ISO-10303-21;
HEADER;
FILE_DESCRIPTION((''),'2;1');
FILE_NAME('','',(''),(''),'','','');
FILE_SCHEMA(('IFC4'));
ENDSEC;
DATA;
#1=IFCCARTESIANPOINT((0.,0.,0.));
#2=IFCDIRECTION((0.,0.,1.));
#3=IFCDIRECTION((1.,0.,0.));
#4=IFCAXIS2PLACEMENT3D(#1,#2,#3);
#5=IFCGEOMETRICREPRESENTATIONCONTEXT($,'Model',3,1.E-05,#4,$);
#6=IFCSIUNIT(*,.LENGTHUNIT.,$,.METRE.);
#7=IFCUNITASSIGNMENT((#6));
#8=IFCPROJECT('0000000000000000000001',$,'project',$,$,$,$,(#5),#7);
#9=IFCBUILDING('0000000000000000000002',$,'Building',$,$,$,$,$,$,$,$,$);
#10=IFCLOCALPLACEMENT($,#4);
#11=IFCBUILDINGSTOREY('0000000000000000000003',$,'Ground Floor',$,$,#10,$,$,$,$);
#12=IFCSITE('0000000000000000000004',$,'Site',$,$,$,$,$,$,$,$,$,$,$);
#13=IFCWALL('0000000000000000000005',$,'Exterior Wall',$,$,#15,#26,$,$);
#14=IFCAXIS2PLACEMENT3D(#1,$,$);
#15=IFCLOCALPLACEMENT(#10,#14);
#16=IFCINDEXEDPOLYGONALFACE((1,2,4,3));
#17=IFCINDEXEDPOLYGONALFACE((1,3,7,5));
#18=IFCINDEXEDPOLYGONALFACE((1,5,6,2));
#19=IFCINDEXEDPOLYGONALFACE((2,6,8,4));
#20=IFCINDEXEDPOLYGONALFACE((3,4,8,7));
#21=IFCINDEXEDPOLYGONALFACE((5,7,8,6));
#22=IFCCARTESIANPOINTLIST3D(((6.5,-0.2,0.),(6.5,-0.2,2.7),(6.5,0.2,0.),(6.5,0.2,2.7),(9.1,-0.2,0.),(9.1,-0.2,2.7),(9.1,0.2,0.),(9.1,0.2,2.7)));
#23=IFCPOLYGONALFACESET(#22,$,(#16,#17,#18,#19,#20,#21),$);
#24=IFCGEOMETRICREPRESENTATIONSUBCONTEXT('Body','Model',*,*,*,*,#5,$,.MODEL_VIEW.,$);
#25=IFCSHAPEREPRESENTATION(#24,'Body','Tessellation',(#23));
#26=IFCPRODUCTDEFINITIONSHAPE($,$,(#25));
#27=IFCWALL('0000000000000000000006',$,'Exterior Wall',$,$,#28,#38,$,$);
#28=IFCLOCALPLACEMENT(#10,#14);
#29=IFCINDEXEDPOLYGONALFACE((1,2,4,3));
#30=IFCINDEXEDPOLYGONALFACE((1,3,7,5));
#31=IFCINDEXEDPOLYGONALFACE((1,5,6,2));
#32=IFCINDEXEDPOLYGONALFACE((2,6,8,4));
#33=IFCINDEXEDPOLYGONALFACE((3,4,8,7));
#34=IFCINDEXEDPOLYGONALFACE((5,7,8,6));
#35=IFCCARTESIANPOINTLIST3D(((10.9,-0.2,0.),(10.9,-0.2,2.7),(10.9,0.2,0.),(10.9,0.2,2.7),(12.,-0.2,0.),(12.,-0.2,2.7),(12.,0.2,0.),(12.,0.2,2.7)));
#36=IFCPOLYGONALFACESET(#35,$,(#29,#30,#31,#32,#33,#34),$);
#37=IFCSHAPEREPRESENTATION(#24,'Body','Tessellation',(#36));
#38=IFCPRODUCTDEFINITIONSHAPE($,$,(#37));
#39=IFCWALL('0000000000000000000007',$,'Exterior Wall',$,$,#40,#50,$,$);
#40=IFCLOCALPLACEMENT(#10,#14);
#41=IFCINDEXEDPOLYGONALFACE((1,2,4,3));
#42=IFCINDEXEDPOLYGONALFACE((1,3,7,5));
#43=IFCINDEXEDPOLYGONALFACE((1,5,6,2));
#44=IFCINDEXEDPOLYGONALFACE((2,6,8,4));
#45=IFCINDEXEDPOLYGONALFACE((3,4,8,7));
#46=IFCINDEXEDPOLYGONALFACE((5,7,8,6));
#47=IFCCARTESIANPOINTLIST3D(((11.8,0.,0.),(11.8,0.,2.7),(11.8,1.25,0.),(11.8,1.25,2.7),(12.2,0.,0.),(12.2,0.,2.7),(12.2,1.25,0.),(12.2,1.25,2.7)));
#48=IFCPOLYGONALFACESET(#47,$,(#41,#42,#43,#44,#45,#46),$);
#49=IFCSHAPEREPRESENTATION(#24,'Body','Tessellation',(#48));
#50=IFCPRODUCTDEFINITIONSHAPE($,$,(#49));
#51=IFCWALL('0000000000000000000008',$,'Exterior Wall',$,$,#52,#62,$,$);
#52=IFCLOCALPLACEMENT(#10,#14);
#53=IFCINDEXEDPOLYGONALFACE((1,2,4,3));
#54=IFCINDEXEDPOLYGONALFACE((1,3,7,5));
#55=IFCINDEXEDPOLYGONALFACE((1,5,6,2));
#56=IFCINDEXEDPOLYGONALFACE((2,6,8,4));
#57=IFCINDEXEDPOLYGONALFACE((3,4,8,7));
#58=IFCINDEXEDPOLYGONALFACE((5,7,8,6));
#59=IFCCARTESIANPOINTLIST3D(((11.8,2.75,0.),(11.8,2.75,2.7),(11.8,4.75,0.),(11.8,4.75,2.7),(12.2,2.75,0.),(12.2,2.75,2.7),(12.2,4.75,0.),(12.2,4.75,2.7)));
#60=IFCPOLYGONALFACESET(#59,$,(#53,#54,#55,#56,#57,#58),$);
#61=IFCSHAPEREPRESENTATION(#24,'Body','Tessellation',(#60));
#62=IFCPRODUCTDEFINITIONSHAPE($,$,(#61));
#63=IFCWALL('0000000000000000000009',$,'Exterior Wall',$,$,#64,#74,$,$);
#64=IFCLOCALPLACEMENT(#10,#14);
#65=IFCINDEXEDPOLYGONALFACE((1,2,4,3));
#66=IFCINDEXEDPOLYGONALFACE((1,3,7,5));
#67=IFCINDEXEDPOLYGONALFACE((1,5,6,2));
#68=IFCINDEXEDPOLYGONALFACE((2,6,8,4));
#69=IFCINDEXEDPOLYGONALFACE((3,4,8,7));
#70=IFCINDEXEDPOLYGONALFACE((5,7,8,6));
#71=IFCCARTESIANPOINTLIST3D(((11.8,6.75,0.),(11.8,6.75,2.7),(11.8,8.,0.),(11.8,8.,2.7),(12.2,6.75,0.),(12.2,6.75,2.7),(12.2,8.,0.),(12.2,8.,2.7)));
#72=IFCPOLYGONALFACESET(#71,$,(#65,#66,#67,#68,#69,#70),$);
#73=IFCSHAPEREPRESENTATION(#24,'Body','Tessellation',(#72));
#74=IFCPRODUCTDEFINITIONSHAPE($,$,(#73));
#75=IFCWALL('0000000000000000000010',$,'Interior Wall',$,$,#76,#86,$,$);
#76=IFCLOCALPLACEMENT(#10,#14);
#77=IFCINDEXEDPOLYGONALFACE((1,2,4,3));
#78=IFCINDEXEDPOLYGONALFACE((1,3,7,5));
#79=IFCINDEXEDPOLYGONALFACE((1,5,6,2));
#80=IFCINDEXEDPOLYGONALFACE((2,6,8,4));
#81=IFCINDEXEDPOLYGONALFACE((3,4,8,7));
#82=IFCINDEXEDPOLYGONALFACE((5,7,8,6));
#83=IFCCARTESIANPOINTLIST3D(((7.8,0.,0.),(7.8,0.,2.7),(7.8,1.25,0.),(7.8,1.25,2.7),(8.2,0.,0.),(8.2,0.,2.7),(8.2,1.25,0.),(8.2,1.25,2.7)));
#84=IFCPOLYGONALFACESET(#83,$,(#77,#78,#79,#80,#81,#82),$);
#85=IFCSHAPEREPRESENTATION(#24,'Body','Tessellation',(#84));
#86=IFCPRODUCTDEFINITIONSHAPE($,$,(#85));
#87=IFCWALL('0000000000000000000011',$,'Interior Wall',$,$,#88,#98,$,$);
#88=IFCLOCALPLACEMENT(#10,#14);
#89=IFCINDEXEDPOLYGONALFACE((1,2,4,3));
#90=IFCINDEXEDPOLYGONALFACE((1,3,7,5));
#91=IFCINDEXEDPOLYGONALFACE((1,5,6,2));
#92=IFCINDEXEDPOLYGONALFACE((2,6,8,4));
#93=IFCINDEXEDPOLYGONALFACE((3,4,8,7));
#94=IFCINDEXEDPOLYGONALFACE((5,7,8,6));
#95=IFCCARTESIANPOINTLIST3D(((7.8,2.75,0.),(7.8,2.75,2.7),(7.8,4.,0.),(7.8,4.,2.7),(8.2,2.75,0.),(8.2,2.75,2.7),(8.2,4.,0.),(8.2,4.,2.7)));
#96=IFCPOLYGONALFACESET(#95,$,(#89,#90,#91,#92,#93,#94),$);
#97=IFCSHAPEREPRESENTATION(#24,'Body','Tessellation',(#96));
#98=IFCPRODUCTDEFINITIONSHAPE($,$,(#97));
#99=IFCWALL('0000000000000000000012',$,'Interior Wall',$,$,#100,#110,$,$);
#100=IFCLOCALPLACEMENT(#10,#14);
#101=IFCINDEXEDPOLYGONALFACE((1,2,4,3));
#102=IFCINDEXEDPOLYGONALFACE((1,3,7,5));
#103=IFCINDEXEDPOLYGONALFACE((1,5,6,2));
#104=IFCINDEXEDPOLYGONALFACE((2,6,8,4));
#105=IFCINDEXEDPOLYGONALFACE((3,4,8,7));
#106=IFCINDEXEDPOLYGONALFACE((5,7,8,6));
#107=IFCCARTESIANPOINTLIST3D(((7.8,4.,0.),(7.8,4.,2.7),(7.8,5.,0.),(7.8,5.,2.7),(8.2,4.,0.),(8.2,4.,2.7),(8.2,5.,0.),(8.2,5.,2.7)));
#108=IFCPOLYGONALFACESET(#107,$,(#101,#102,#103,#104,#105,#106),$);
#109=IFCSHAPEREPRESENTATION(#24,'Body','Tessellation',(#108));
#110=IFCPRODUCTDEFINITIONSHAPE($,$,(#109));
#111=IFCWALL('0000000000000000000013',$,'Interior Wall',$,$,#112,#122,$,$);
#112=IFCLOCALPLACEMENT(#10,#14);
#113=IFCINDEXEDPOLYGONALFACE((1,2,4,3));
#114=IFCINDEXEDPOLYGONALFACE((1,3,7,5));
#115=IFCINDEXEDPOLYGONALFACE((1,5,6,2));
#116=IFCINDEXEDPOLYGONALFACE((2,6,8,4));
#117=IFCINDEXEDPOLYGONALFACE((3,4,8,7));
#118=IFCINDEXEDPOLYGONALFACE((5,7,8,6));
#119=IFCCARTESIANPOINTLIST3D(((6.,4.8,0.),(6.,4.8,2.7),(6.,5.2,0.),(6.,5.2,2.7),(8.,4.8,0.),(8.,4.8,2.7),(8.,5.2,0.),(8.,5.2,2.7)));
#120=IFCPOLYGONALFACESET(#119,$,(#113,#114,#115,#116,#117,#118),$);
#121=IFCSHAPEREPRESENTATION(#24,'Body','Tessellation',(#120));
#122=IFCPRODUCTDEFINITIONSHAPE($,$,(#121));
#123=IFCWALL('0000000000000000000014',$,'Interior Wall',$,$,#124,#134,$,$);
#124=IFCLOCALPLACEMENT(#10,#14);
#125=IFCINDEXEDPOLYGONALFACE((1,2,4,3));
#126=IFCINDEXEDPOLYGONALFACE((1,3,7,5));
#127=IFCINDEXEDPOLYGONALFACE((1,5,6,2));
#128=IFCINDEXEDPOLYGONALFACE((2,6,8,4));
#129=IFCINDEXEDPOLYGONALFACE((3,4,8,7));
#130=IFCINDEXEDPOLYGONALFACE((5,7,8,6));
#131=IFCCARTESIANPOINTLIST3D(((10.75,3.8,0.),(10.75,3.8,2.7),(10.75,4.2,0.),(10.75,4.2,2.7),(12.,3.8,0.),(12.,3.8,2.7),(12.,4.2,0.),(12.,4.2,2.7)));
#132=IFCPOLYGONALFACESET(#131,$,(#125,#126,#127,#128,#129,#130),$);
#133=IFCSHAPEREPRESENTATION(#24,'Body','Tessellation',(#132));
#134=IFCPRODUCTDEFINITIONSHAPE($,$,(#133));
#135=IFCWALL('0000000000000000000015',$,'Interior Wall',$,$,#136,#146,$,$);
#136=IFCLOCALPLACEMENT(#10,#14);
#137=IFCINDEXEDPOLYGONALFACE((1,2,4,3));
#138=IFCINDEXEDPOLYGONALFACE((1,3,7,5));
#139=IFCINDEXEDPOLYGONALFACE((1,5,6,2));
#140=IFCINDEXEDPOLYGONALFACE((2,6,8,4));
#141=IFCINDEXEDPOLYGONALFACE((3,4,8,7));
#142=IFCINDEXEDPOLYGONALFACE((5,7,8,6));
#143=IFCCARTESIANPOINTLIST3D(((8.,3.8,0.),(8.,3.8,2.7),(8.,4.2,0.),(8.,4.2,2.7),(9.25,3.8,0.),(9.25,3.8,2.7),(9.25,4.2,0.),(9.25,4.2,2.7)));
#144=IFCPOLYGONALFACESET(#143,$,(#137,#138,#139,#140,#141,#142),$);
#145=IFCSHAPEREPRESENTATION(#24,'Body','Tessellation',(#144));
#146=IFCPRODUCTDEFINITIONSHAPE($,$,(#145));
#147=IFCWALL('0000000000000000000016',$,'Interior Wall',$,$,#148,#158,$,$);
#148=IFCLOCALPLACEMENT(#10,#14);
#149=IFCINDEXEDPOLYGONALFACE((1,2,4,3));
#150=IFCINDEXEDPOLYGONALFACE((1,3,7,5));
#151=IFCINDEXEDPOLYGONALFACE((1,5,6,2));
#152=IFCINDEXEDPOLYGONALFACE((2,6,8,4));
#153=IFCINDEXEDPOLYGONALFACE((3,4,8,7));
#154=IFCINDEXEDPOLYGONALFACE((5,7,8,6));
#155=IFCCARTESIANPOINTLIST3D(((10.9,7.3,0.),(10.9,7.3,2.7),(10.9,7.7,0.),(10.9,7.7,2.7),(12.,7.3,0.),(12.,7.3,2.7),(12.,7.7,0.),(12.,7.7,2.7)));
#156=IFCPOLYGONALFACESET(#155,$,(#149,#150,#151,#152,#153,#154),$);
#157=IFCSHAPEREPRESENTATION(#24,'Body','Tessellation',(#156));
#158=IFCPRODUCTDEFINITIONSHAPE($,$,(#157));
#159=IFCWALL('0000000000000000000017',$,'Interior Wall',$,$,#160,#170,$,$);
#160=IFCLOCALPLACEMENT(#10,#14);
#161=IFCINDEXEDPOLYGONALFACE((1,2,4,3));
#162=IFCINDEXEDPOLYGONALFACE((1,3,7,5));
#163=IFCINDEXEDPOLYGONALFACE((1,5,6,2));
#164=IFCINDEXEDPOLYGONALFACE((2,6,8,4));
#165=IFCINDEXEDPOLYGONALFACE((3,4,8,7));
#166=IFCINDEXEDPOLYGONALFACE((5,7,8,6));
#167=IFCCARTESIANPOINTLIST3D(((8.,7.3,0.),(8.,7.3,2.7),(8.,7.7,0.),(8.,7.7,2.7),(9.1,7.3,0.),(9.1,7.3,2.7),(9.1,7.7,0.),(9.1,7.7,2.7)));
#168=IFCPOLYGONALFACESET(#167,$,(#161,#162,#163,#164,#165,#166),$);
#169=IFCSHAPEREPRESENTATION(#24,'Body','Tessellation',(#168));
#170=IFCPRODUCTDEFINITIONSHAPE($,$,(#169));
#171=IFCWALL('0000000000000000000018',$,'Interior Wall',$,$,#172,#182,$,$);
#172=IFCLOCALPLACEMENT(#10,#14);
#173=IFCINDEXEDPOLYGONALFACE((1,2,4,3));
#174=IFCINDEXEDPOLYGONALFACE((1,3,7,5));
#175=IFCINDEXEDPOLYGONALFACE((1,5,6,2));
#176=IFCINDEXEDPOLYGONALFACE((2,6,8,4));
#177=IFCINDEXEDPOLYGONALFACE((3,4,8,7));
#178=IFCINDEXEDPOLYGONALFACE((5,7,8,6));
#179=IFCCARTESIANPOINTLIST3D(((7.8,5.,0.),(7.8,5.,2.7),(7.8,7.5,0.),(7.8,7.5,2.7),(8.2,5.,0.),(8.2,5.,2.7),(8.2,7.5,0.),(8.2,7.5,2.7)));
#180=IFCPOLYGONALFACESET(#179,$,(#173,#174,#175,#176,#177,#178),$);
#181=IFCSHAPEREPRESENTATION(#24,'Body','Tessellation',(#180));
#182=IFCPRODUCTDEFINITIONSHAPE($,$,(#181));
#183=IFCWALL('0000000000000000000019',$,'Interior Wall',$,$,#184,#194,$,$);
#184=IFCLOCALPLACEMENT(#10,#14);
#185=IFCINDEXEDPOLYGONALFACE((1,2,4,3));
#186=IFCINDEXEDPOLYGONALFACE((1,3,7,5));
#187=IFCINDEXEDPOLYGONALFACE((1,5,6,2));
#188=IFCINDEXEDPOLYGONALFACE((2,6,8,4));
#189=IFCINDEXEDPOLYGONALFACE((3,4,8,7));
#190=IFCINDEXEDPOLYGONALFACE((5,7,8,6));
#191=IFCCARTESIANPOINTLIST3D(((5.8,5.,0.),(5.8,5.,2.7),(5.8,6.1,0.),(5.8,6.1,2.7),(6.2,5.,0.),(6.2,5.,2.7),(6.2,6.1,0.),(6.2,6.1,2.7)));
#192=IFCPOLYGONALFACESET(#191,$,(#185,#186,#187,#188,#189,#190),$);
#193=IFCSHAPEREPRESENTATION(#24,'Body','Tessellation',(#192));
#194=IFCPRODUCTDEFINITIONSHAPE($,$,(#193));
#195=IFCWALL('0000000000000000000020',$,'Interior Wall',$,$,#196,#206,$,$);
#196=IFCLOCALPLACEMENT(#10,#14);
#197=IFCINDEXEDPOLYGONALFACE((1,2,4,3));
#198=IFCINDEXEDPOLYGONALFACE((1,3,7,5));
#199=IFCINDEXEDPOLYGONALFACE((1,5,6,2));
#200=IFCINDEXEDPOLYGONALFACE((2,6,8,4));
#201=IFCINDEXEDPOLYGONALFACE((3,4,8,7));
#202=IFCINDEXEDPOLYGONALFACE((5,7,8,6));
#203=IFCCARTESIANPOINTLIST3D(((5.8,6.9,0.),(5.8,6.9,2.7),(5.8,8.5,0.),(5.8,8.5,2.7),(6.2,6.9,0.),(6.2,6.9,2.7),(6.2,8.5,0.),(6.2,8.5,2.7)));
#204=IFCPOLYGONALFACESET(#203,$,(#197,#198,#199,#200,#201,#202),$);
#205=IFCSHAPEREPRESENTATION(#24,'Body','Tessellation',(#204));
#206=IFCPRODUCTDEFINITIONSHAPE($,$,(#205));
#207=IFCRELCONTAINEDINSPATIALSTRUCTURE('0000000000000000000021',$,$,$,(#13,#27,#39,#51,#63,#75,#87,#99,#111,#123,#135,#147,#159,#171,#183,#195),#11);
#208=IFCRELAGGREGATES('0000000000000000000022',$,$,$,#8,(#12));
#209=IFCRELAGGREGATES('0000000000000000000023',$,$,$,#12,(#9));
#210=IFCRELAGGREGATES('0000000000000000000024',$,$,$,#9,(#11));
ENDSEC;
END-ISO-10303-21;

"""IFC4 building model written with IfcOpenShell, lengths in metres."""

from ifc_helpers import new_model, si_unit, frame, origin_with_axes, place, context, subcontext, project, spatial, indexed_curve, outline, extrude, element, save


model = new_model("IFC4")

# Units and contexts
model_context = context("Model", 3, precision=1e-05, world=origin_with_axes())
body_context = subcontext(model_context, "Body", "Model", "MODEL_VIEW")
ifc_project = project(units=[si_unit("LENGTHUNIT", "METRE")], contexts=[model_context])

# Site, building, storey
site = spatial("IfcSite", under=ifc_project, Name="Site")
building = spatial("IfcBuilding", under=site, Name="Building")
storey_placement = place(None, origin_with_axes())
storey = spatial("IfcBuildingStorey", under=building, at=storey_placement, Name="Ground Floor")

# Walls
wall_1_placement = place(storey_placement, frame((6.5, 0.0, 0.0), z_axis=(0.0, 0.0, 1.0), x_axis=(1.0, 0.0, 0.0)))
element("IfcWall", 1, at=wall_1_placement, inside=storey, Name="Exterior Wall", context=body_context, shape_type="SweptSolid", body=[
    extrude(outline(indexed_curve([(0.0, 0.0), (0.0, 0.4), (2.6, 0.4), (2.6, 0.0), (0.0, 0.0)], self_intersect=False)), frame((0.0, -0.2, 0.0), z_axis=(0.0, 0.0, 1.0), x_axis=(1.0, 0.0, 0.0)), (0.0, 0.0, 1.0), 2.7),
])
wall_2_placement = place(storey_placement, frame((10.9, 0.0, 0.0), z_axis=(0.0, 0.0, 1.0), x_axis=(1.0, 0.0, 0.0)))
element("IfcWall", 2, at=wall_2_placement, inside=storey, Name="Exterior Wall", context=body_context, shape_type="SweptSolid", body=[
    extrude(outline(indexed_curve([(0.0, 0.0), (0.0, 0.4), (1.1, 0.4), (1.1, 0.0), (0.0, 0.0)], self_intersect=False)), frame((0.0, -0.2, 0.0), z_axis=(0.0, 0.0, 1.0), x_axis=(1.0, 0.0, 0.0)), (0.0, 0.0, 1.0), 2.7),
])
wall_3_placement = place(storey_placement, frame((12.0, 0.0, 0.0), z_axis=(0.0, 0.0, 1.0), x_axis=(0.0, 1.0, 0.0)))
element("IfcWall", 3, at=wall_3_placement, inside=storey, Name="Exterior Wall", context=body_context, shape_type="SweptSolid", body=[
    extrude(outline(indexed_curve([(0.0, 0.0), (0.0, 0.4), (1.25, 0.4), (1.25, 0.0), (0.0, 0.0)], self_intersect=False)), frame((0.0, -0.2, 0.0), z_axis=(0.0, 0.0, 1.0), x_axis=(1.0, 0.0, 0.0)), (0.0, 0.0, 1.0), 2.7),
])
wall_4_placement = place(storey_placement, frame((12.0, 2.75, 0.0), z_axis=(0.0, 0.0, 1.0), x_axis=(0.0, 1.0, 0.0)))
element("IfcWall", 4, at=wall_4_placement, inside=storey, Name="Exterior Wall", context=body_context, shape_type="SweptSolid", body=[
    extrude(outline(indexed_curve([(0.0, 0.0), (0.0, 0.4), (2.0, 0.4), (2.0, 0.0), (0.0, 0.0)], self_intersect=False)), frame((0.0, -0.2, 0.0), z_axis=(0.0, 0.0, 1.0), x_axis=(1.0, 0.0, 0.0)), (0.0, 0.0, 1.0), 2.7),
])
for number, where, z_axis, x_axis, name in (
    (5, (12.0, 6.75, 0.0), (0.0, 0.0, 1.0), (0.0, 1.0, 0.0), "Exterior Wall"),
    (6, (8.0, 0.0, 0.0), (0.0, 0.0, 1.0), (0.0, 1.0, 0.0), "Interior Wall"),
    (7, (8.0, 2.75, 0.0), (0.0, 0.0, 1.0), (0.0, 1.0, 0.0), "Interior Wall"),
):
    element("IfcWall", number, at=place(storey_placement, frame(where, z_axis=z_axis, x_axis=x_axis)), inside=storey, Name=name, context=body_context, shape_type="SweptSolid", body=[
        extrude(outline(indexed_curve([(0.0, 0.0), (0.0, 0.4), (1.25, 0.4), (1.25, 0.0), (0.0, 0.0)], self_intersect=False)), frame((0.0, -0.2, 0.0), z_axis=(0.0, 0.0, 1.0), x_axis=(1.0, 0.0, 0.0)), (0.0, 0.0, 1.0), 2.7),
    ])
wall_5_placement = place(storey_placement, frame((8.0, 4.0, 0.0), z_axis=(0.0, 0.0, 1.0), x_axis=(0.0, 1.0, 0.0)))
element("IfcWall", 8, at=wall_5_placement, inside=storey, Name="Interior Wall", context=body_context, shape_type="SweptSolid", body=[
    extrude(outline(indexed_curve([(0.0, 0.0), (0.0, 0.4), (1.0, 0.4), (1.0, 0.0), (0.0, 0.0)], self_intersect=False)), frame((0.0, -0.2, 0.0), z_axis=(0.0, 0.0, 1.0), x_axis=(1.0, 0.0, 0.0)), (0.0, 0.0, 1.0), 2.7),
])
wall_6_placement = place(storey_placement, frame((8.0, 5.0, 0.0), z_axis=(0.0, 0.0, 1.0), x_axis=(-1.0, 0.0, 0.0)))
element("IfcWall", 9, at=wall_6_placement, inside=storey, Name="Interior Wall", context=body_context, shape_type="SweptSolid", body=[
    extrude(outline(indexed_curve([(0.0, 0.0), (0.0, 0.4), (2.0, 0.4), (2.0, 0.0), (0.0, 0.0)], self_intersect=False)), frame((0.0, -0.2, 0.0), z_axis=(0.0, 0.0, 1.0), x_axis=(1.0, 0.0, 0.0)), (0.0, 0.0, 1.0), 2.7),
])
for number, where, z_axis, x_axis, name in (
    (10, (12.0, 4.0, 0.0), (0.0, 0.0, 1.0), (-1.0, 0.0, 0.0), "Interior Wall"),
    (11, (9.25, 4.0, 0.0), (0.0, 0.0, 1.0), (-1.0, 0.0, 0.0), "Interior Wall"),
):
    element("IfcWall", number, at=place(storey_placement, frame(where, z_axis=z_axis, x_axis=x_axis)), inside=storey, Name=name, context=body_context, shape_type="SweptSolid", body=[
        extrude(outline(indexed_curve([(0.0, 0.0), (0.0, 0.4), (1.25, 0.4), (1.25, 0.0), (0.0, 0.0)], self_intersect=False)), frame((0.0, -0.2, 0.0), z_axis=(0.0, 0.0, 1.0), x_axis=(1.0, 0.0, 0.0)), (0.0, 0.0, 1.0), 2.7),
    ])
for number, where, z_axis, x_axis, name in (
    (12, (12.0, 7.5, 0.0), (0.0, 0.0, 1.0), (-1.0, 0.0, 0.0), "Interior Wall"),
    (13, (9.1, 7.5, 0.0), (0.0, 0.0, 1.0), (-1.0, 0.0, 0.0), "Interior Wall"),
):
    element("IfcWall", number, at=place(storey_placement, frame(where, z_axis=z_axis, x_axis=x_axis)), inside=storey, Name=name, context=body_context, shape_type="SweptSolid", body=[
        extrude(outline(indexed_curve([(0.0, 0.0), (0.0, 0.4), (1.1, 0.4), (1.1, 0.0), (0.0, 0.0)], self_intersect=False)), frame((0.0, -0.2, 0.0), z_axis=(0.0, 0.0, 1.0), x_axis=(1.0, 0.0, 0.0)), (0.0, 0.0, 1.0), 2.7),
    ])
wall_7_placement = place(storey_placement, frame((8.0, 7.5, 0.0), z_axis=(0.0, 0.0, 1.0), x_axis=(0.0, -1.0, 0.0)))
element("IfcWall", 14, at=wall_7_placement, inside=storey, Name="Interior Wall", context=body_context, shape_type="SweptSolid", body=[
    extrude(outline(indexed_curve([(0.0, 0.0), (0.0, 0.4), (2.5, 0.4), (2.5, 0.0), (0.0, 0.0)], self_intersect=False)), frame((0.0, -0.2, 0.0), z_axis=(0.0, 0.0, 1.0), x_axis=(1.0, 0.0, 0.0)), (0.0, 0.0, 1.0), 2.7),
])
wall_8_placement = place(storey_placement, frame((6.0, 5.0, 0.0), z_axis=(0.0, 0.0, 1.0), x_axis=(0.0, 1.0, 0.0)))
element("IfcWall", 15, at=wall_8_placement, inside=storey, Name="Interior Wall", context=body_context, shape_type="SweptSolid", body=[
    extrude(outline(indexed_curve([(0.0, 0.0), (0.0, 0.4), (1.1, 0.4), (1.1, 0.0), (0.0, 0.0)], self_intersect=False)), frame((0.0, -0.2, 0.0), z_axis=(0.0, 0.0, 1.0), x_axis=(1.0, 0.0, 0.0)), (0.0, 0.0, 1.0), 2.7),
])
wall_9_placement = place(storey_placement, frame((6.0, 6.9, 0.0), z_axis=(0.0, 0.0, 1.0), x_axis=(0.0, 1.0, 0.0)))
element("IfcWall", 16, at=wall_9_placement, inside=storey, Name="Interior Wall", context=body_context, shape_type="SweptSolid", body=[
    extrude(outline(indexed_curve([(0.0, 0.0), (0.0, 0.4), (1.6, 0.4), (1.6, 0.0), (0.0, 0.0)], self_intersect=False)), frame((0.0, -0.2, 0.0), z_axis=(0.0, 0.0, 1.0), x_axis=(1.0, 0.0, 0.0)), (0.0, 0.0, 1.0), 2.7),
])

save(model, "model.ifc")
